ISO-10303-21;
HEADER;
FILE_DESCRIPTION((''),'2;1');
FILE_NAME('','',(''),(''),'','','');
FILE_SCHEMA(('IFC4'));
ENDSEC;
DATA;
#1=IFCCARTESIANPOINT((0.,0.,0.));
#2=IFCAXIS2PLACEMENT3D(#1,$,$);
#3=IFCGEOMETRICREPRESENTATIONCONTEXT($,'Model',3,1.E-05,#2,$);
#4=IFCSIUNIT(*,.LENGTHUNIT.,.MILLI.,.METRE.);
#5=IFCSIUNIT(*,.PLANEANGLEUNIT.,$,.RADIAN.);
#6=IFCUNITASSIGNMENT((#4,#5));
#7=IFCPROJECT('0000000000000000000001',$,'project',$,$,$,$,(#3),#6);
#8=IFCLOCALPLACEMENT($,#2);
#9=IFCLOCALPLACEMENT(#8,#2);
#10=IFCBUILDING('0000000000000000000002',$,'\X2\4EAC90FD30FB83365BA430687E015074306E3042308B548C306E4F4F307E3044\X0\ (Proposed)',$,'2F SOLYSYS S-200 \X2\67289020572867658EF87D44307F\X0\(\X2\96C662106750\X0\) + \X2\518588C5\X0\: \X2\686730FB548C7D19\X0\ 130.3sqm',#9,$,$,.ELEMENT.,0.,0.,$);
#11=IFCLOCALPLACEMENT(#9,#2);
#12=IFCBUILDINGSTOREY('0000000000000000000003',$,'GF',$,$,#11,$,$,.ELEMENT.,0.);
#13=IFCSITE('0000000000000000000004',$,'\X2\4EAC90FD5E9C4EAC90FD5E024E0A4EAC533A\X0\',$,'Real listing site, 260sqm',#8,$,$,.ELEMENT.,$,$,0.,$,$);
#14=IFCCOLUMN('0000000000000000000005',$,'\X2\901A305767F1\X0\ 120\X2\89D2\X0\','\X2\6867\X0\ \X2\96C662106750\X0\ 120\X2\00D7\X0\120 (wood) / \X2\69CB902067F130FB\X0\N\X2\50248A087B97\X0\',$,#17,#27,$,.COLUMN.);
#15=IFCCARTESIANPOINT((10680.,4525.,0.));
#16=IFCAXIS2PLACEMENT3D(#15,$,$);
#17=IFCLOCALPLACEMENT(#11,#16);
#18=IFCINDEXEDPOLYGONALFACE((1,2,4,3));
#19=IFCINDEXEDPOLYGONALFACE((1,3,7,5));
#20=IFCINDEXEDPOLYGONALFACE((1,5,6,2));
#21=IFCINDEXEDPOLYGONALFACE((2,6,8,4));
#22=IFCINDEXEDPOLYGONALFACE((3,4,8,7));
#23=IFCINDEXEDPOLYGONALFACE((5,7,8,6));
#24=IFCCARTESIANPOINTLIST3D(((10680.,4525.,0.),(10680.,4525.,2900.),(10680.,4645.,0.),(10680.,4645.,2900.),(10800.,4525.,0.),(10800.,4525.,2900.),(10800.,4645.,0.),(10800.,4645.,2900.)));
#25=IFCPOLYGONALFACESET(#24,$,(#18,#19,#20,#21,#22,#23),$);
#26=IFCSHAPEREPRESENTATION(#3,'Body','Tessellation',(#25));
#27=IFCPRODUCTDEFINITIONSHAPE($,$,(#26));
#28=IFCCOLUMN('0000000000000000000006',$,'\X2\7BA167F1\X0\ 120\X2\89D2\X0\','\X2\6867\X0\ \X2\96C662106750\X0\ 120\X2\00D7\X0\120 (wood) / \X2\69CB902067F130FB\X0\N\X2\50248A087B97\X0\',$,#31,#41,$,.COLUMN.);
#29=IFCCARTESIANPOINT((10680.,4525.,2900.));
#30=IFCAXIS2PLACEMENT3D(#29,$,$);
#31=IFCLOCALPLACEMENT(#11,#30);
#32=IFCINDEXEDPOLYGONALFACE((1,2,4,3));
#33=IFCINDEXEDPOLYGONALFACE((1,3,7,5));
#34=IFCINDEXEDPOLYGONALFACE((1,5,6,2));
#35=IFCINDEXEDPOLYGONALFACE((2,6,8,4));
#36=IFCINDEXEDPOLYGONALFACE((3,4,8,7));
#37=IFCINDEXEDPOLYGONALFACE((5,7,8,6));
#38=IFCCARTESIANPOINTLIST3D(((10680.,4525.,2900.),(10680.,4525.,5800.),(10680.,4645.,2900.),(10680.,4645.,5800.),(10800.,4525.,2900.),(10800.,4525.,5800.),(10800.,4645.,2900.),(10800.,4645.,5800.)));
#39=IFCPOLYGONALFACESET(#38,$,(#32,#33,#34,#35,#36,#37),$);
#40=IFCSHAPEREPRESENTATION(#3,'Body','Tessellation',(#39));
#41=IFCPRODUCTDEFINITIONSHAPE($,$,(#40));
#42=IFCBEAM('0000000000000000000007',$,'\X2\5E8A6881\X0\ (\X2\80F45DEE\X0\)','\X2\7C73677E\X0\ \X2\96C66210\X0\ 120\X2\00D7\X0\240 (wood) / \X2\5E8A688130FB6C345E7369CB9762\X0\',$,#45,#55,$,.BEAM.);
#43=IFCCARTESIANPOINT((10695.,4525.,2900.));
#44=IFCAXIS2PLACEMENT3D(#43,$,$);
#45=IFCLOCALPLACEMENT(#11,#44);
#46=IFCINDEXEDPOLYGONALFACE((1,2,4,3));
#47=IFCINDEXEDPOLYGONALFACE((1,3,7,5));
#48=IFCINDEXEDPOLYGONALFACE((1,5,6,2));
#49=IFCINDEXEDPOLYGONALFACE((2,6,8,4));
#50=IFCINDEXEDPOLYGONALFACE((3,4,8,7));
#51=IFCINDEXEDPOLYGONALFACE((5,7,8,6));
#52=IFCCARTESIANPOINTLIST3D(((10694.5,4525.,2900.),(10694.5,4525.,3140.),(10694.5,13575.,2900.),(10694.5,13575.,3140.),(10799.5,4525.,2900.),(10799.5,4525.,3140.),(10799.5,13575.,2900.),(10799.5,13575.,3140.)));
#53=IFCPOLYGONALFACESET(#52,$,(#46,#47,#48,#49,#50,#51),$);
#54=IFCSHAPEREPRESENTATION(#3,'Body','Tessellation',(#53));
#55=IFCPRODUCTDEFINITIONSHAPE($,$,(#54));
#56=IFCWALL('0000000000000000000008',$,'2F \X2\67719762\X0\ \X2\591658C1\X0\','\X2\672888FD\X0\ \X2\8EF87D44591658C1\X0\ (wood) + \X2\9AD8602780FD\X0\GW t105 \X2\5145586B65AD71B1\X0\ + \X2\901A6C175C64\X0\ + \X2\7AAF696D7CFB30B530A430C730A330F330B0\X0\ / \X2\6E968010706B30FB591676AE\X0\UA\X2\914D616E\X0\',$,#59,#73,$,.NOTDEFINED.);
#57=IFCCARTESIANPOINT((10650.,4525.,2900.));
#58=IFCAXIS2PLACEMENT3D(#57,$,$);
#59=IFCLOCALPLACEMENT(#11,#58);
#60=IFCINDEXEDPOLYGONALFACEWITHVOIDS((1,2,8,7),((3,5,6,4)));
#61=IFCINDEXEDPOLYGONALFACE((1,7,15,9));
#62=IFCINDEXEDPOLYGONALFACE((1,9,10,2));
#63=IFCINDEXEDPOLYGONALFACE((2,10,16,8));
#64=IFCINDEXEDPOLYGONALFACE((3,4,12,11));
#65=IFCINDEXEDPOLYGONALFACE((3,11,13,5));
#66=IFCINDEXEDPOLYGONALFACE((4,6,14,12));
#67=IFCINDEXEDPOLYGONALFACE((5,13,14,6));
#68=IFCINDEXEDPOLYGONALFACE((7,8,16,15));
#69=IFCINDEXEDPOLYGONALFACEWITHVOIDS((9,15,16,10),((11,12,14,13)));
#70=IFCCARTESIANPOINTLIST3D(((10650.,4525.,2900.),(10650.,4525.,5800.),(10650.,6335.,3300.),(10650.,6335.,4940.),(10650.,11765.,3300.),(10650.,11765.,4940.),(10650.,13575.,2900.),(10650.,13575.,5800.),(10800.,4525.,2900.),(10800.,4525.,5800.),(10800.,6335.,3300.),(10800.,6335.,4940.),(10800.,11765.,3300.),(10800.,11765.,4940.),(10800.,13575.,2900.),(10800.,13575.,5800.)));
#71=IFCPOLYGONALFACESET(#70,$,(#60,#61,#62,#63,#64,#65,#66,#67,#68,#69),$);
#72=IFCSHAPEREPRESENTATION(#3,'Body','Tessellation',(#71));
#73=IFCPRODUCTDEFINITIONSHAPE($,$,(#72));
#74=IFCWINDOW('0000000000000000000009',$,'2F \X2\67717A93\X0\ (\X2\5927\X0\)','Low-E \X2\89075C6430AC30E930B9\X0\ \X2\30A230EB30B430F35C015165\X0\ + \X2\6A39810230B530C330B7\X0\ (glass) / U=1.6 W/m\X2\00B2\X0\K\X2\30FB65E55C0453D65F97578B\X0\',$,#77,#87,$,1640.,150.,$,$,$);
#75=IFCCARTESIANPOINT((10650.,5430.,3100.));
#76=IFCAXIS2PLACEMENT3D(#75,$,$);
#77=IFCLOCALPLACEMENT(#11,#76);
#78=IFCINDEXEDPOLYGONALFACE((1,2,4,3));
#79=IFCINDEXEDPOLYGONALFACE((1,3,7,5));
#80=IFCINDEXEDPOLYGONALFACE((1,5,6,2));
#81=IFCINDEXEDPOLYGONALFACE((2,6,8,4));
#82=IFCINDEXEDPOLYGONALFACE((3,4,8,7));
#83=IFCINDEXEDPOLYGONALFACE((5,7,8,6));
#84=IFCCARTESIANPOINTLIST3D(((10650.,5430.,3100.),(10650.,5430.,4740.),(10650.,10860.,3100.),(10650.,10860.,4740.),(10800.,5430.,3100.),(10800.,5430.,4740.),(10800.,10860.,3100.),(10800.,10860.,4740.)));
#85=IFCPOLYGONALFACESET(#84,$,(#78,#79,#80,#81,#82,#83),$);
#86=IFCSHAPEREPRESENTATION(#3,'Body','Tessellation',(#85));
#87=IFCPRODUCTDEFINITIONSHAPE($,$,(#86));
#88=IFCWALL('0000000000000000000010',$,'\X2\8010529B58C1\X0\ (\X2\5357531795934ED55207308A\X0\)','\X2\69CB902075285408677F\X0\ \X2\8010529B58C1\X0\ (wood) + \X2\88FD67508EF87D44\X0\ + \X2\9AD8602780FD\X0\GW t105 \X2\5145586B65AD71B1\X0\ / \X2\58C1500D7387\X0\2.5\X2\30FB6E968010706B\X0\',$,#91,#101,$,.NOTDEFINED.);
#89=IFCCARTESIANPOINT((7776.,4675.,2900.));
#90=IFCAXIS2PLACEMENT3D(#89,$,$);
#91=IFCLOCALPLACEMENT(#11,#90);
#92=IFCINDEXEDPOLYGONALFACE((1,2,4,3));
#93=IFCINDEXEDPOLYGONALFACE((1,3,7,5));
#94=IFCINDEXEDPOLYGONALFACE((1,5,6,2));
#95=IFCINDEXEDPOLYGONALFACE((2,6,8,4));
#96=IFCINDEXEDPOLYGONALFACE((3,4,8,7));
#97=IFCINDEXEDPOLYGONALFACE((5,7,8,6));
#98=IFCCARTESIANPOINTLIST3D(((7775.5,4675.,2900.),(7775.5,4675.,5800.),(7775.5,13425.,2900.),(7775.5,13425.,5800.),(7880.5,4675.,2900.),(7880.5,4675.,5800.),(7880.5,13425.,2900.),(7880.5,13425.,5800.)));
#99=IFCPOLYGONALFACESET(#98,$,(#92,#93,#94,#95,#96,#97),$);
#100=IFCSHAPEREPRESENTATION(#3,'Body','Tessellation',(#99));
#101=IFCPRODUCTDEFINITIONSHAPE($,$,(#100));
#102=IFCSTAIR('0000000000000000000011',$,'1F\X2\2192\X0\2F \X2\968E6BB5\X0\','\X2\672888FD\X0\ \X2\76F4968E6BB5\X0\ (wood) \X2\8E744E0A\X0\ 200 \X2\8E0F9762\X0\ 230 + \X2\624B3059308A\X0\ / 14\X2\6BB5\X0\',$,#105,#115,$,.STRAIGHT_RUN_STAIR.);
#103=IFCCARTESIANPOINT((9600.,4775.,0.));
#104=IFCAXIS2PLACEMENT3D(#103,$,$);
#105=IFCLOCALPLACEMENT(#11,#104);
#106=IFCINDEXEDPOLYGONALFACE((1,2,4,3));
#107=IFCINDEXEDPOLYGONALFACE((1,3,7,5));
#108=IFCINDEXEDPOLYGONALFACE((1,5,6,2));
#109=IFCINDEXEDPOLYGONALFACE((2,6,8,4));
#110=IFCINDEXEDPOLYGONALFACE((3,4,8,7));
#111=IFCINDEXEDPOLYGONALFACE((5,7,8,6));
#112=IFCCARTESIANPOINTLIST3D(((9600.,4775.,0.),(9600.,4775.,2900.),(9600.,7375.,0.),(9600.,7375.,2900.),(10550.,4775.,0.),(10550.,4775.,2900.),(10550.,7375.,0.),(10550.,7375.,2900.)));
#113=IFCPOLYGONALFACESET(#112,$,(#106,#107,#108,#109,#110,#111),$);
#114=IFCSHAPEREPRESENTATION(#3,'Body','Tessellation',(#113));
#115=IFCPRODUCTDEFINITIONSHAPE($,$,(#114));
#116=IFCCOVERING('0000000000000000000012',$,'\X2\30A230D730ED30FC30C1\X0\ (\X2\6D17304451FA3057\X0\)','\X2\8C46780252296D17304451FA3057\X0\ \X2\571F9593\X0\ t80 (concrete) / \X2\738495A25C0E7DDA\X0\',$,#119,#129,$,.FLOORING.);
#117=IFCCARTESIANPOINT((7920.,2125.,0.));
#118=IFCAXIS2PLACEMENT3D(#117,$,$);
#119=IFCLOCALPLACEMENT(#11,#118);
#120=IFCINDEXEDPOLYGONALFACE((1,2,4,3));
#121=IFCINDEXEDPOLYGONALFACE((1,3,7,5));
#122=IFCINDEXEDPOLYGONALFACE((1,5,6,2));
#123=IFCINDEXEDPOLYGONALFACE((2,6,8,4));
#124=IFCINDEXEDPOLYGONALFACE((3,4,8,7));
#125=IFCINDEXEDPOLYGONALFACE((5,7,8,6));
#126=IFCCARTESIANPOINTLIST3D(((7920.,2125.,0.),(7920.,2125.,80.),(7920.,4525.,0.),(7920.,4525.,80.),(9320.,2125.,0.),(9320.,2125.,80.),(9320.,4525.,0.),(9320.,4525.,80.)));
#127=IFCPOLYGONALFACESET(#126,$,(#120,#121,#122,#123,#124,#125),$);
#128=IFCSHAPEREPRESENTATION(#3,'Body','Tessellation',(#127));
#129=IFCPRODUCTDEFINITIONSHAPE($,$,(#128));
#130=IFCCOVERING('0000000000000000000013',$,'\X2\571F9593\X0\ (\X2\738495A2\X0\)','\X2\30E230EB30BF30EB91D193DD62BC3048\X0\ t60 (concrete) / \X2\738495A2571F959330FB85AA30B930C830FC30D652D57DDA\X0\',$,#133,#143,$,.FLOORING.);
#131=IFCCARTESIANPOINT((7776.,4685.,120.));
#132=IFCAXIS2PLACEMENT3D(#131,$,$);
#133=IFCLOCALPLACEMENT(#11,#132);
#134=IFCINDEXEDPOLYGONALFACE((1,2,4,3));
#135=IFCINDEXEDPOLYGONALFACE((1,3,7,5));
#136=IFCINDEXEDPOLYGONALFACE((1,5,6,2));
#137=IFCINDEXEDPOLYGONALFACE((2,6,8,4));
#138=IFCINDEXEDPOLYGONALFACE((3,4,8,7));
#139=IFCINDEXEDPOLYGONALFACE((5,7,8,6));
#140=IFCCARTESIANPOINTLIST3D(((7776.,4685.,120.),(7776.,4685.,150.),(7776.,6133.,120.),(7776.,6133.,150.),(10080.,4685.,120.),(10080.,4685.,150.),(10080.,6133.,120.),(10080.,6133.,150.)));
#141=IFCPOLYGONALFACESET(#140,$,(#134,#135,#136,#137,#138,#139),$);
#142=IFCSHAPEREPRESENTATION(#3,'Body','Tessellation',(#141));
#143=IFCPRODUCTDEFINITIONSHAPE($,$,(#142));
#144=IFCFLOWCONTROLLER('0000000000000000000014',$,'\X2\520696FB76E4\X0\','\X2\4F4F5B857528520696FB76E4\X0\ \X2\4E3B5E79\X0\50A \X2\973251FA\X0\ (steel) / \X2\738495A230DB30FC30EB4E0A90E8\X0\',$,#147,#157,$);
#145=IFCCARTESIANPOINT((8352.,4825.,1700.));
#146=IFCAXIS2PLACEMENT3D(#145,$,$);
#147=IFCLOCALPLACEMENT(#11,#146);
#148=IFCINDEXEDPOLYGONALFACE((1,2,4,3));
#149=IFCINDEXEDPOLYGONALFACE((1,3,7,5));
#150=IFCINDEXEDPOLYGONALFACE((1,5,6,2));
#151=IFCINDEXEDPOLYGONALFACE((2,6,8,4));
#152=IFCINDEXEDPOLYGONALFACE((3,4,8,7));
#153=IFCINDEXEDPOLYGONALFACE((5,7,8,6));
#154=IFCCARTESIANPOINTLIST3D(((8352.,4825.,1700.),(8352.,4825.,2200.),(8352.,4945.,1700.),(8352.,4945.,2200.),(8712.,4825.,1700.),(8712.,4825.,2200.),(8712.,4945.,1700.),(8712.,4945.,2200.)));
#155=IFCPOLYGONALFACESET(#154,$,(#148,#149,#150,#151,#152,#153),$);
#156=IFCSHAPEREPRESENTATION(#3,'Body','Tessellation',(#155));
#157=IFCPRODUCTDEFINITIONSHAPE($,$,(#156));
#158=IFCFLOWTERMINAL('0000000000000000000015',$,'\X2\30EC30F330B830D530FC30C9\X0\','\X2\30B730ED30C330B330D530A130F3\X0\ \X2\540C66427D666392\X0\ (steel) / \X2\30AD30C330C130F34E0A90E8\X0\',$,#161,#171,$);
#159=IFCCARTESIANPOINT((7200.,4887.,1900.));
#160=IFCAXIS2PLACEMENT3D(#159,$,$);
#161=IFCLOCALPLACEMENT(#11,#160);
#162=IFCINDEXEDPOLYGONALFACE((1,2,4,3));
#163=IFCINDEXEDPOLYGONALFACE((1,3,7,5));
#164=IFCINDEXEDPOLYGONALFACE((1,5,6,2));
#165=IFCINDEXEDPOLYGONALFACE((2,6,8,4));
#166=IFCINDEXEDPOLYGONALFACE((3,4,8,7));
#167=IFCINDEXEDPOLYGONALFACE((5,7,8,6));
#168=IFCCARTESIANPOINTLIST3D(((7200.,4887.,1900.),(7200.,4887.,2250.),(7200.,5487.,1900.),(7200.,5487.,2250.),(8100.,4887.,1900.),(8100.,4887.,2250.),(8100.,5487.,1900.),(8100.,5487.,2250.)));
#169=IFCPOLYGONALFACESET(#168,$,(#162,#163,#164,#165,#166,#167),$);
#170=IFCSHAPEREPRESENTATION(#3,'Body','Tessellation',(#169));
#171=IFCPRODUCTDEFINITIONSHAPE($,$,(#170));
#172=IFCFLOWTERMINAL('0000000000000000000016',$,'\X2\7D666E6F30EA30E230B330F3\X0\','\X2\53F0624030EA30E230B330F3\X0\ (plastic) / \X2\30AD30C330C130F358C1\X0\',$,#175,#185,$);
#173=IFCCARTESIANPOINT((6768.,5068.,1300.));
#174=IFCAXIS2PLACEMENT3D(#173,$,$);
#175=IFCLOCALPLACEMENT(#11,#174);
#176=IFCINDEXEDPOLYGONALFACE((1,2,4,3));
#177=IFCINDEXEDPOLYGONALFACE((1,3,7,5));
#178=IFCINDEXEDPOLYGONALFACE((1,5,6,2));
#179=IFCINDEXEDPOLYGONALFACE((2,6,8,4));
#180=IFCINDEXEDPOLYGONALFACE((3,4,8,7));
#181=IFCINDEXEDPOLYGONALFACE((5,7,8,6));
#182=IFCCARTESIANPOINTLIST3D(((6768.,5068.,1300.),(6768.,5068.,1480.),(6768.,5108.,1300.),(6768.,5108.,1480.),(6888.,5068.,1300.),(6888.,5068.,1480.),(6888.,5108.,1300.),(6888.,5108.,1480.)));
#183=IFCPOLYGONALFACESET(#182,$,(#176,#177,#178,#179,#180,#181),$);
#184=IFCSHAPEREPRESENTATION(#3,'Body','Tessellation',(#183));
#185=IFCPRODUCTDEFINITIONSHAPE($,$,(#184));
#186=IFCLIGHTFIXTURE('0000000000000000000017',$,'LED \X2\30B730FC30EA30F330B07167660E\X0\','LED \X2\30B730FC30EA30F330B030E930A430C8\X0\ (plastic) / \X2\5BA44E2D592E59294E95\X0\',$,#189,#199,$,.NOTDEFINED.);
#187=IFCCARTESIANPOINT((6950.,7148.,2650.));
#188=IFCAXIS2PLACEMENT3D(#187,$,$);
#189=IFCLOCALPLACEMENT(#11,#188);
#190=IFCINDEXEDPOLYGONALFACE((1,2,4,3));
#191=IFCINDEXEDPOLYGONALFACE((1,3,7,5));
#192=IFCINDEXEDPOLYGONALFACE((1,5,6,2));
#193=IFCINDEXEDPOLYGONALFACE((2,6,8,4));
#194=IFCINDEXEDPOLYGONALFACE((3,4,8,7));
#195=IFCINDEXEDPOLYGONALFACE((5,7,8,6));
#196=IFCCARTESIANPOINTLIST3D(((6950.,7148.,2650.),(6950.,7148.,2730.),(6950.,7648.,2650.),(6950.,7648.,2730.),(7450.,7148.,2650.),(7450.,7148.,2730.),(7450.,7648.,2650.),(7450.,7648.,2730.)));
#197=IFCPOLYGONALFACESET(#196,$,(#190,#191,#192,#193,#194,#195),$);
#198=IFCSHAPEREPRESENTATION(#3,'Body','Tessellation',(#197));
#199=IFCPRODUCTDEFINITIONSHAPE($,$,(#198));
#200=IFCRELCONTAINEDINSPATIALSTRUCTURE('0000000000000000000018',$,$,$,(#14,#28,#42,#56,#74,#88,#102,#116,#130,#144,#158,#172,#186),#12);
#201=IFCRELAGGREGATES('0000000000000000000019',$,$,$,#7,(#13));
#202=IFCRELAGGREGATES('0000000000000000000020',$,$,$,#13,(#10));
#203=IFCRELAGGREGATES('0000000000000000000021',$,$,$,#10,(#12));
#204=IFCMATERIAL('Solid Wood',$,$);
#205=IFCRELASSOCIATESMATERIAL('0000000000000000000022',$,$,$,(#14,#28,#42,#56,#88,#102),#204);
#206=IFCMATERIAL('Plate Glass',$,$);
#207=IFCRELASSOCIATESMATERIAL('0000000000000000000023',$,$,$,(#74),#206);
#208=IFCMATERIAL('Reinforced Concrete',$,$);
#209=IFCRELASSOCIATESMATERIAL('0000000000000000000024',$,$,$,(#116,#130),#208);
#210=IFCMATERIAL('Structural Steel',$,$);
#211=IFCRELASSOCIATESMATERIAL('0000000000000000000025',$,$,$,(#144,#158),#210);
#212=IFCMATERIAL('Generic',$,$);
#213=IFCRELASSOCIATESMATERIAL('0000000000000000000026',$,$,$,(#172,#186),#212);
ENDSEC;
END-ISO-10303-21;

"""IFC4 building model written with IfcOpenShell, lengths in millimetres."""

from ifc_helpers import new_model, si_unit, frame, frame_2d, origin, place, context, project, spatial, rectangle, extrude, material, element, fill, save


model = new_model("IFC4")

# Units and contexts
model_context = context("Model", 3, precision=1e-05, world=origin())
ifc_project = project(units=[si_unit("LENGTHUNIT", "METRE", prefix="MILLI"), si_unit("PLANEANGLEUNIT", "RADIAN")], contexts=[model_context])

# Site, building, storey
site_placement = place(None, origin())
site = spatial("IfcSite", under=ifc_project, at=site_placement, Name="京都府京都市上京区", ObjectType="Real listing site, 260sqm", CompositionType="ELEMENT", RefElevation=0.0)
building_placement = place(site_placement, origin())
building = spatial("IfcBuilding", under=site, at=building_placement, Name="京都・茶室と縁側のある和の住まい (Proposed)", ObjectType="2F SOLYSYS S-200 木造在来軸組み(集成材) + 内装: 桧・和紙 130.3sqm", CompositionType="ELEMENT", ElevationOfRefHeight=0.0, ElevationOfTerrain=0.0)
storey_placement = place(building_placement, origin())
storey = spatial("IfcBuildingStorey", under=building, at=storey_placement, Name="GF", CompositionType="ELEMENT", Elevation=0.0)

# Columns
ifc_material_1 = material(Name="Solid Wood")
column_1_placement = place(storey_placement, frame((10680.0, 4525.0, 0.0)))
element("IfcColumn", 1, at=column_1_placement, inside=storey, material=ifc_material_1, Name="通し柱 120角", Description="桧 集成材 120×120 (wood) / 構造柱・N値計算", PredefinedType="COLUMN", context=model_context, shape_type="SweptSolid", body=[
    extrude(rectangle(XDim=120.0, YDim=120.0, at=frame_2d((60.0, 60.0))), frame((10680.0, 4525.0, 0.0)), (0.0, 0.0, 1.0), 2900.0),
])
column_2_placement = place(storey_placement, frame((10680.0, 4525.0, 2900.0)))
element("IfcColumn", 2, at=column_2_placement, inside=storey, material=ifc_material_1, Name="管柱 120角", Description="桧 集成材 120×120 (wood) / 構造柱・N値計算", PredefinedType="COLUMN", context=model_context, shape_type="SweptSolid", body=[
    extrude(rectangle(XDim=120.0, YDim=120.0, at=frame_2d((60.0, 60.0))), frame((10680.0, 4525.0, 2900.0)), (0.0, 0.0, 1.0), 2900.0),
])

# Beam
beam_1_placement = place(storey_placement, frame((10695.0, 4525.0, 2900.0)))
element("IfcBeam", 3, at=beam_1_placement, inside=storey, material=ifc_material_1, Name="床梁 (胴差)", Description="米松 集成 120×240 (wood) / 床梁・水平構面", PredefinedType="BEAM", context=model_context, shape_type="SweptSolid", body=[
    extrude(rectangle(XDim=105.0, YDim=9050.0, at=frame_2d((52.0, 4525.0))), frame((10695.0, 4525.0, 2900.0)), (0.0, 0.0, 1.0), 240.0),
])

# Shared definitions
ifc_material_2 = material(Name="Plate Glass")

# Wall, opening, window
wall_1_placement = place(storey_placement, frame((10650.0, 4525.0, 2900.0)))
wall_1 = element("IfcWall", 4, at=wall_1_placement, inside=storey, material=ifc_material_1, Name="2F 東面 外壁", Description="木製 軸組外壁 (wood) + 高性能GW t105 充填断熱 + 通気層 + 窯業系サイディング / 準耐火・外皮UA配慮", PredefinedType="NOTDEFINED", context=model_context, shape_type="SweptSolid", body=[
    extrude(rectangle(XDim=150.0, YDim=9050.0, at=frame_2d((75.0, 4525.0))), frame((10650.0, 4525.0, 2900.0)), (0.0, 0.0, 1.0), 2900.0),
])
opening_1_placement = place(storey_placement, frame((10650.0, 5430.0, 3100.0)))
opening_1 = element("IfcOpeningElement", 5, at=opening_1_placement, cuts=wall_1, PredefinedType="NOTDEFINED", context=model_context, shape_type="SweptSolid", body=[
    extrude(rectangle(XDim=150.0, YDim=5430.0, at=frame_2d((75.0, 2715.0))), frame((10650.0, 5430.0, 3100.0)), (0.0, 0.0, 1.0), 1640.0),
])
window_1_placement = place(storey_placement, frame((10650.0, 5430.0, 3100.0)))
window_1 = element("IfcWindow", 6, at=window_1_placement, inside=storey, material=ifc_material_2, Name="2F 東窓 (大)", Description="Low-E 複層ガラス アルゴン封入 + 樹脂サッシ (glass) / U=1.6 W/m²K・日射取得型", OverallHeight=1640.0, OverallWidth=150.0, context=model_context, shape_type="SweptSolid", body=[
    extrude(rectangle(XDim=150.0, YDim=5430.0, at=frame_2d((75.0, 2715.0))), frame((10650.0, 5430.0, 3100.0)), (0.0, 0.0, 1.0), 1640.0),
])
fill(opening_1, window_1)

# Wall
wall_2_placement = place(storey_placement, frame((7776.0, 4675.0, 2900.0)))
element("IfcWall", 7, at=wall_2_placement, inside=storey, material=ifc_material_1, Name="耐力壁 (南北間仕切り)", Description="構造用合板 耐力壁 (wood) + 製材軸組 + 高性能GW t105 充填断熱 / 壁倍率2.5・準耐火", PredefinedType="NOTDEFINED", context=model_context, shape_type="SweptSolid", body=[
    extrude(rectangle(XDim=105.0, YDim=8750.0, at=frame_2d((52.0, 4375.0))), frame((7776.0, 4675.0, 2900.0)), (0.0, 0.0, 1.0), 2900.0),
])

# Stair
stair_placement = place(storey_placement, frame((9600.0, 4775.0, 0.0)))
element("IfcStair", 8, at=stair_placement, inside=storey, material=ifc_material_1, Name="1F→2F 階段", Description="木製 直階段 (wood) 蹴上 200 踏面 230 + 手すり / 14段", PredefinedType="STRAIGHT_RUN_STAIR", context=model_context, shape_type="SweptSolid", body=[
    extrude(rectangle(XDim=950.0, YDim=2600.0, at=frame_2d((475.0, 1300.0))), frame((9600.0, 4775.0, 0.0)), (0.0, 0.0, 1.0), 2900.0),
])

# Coverings
ifc_material_3 = material(Name="Reinforced Concrete")
covering_1_placement = place(storey_placement, frame((7920.0, 2125.0, 0.0)))
element("IfcCovering", 9, at=covering_1_placement, inside=storey, material=ifc_material_3, Name="アプローチ (洗い出し)", Description="豆砂利洗い出し 土間 t80 (concrete) / 玄関導線", PredefinedType="FLOORING", context=model_context, shape_type="SweptSolid", body=[
    extrude(rectangle(XDim=1400.0, YDim=2400.0, at=frame_2d((700.0, 1200.0))), frame((7920.0, 2125.0, 0.0)), (0.0, 0.0, 1.0), 80.0),
])
covering_2_placement = place(storey_placement, frame((7776.0, 4685.0, 120.0)))
element("IfcCovering", 10, at=covering_2_placement, inside=storey, material=ifc_material_3, Name="土間 (玄関)", Description="モルタル金鏝押え t60 (concrete) / 玄関土間・薪ストーブ動線", PredefinedType="FLOORING", context=model_context, shape_type="SweptSolid", body=[
    extrude(rectangle(XDim=2304.0, YDim=1448.0, at=frame_2d((1152.0, 724.0))), frame((7776.0, 4685.0, 120.0)), (0.0, 0.0, 1.0), 30.0),
])

# Flow controller
ifc_material_4 = material(Name="Structural Steel")
flow_controller_placement = place(storey_placement, frame((8352.0, 4825.0, 1700.0)))
element("IfcFlowController", 11, at=flow_controller_placement, inside=storey, material=ifc_material_4, Name="分電盤", Description="住宅用分電盤 主幹50A 露出 (steel) / 玄関ホール上部", context=model_context, shape_type="SweptSolid", body=[
    extrude(rectangle(XDim=360.0, YDim=120.0, at=frame_2d((180.0, 60.0))), frame((8352.0, 4825.0, 1700.0)), (0.0, 0.0, 1.0), 500.0),
])

# Flow terminals
flow_terminal_1_placement = place(storey_placement, frame((7200.0, 4887.0, 1900.0)))
element("IfcFlowTerminal", 12, at=flow_terminal_1_placement, inside=storey, material=ifc_material_4, Name="レンジフード", Description="シロッコファン 同時給排 (steel) / キッチン上部", context=model_context, shape_type="SweptSolid", body=[
    extrude(rectangle(XDim=900.0, YDim=600.0, at=frame_2d((450.0, 300.0))), frame((7200.0, 4887.0, 1900.0)), (0.0, 0.0, 1.0), 350.0),
])
ifc_material_5 = material(Name="Generic")
flow_terminal_2_placement = place(storey_placement, frame((6768.0, 5068.0, 1300.0)))
element("IfcFlowTerminal", 13, at=flow_terminal_2_placement, inside=storey, material=ifc_material_5, Name="給湯リモコン", Description="台所リモコン (plastic) / キッチン壁", context=model_context, shape_type="SweptSolid", body=[
    extrude(rectangle(XDim=120.0, YDim=40.0, at=frame_2d((60.0, 20.0))), frame((6768.0, 5068.0, 1300.0)), (0.0, 0.0, 1.0), 180.0),
])

# Light fixture
light_fixture_1_placement = place(storey_placement, frame((6950.0, 7148.0, 2650.0)))
element("IfcLightFixture", 14, at=light_fixture_1_placement, inside=storey, material=ifc_material_5, Name="LED シーリング照明", Description="LED シーリングライト (plastic) / 室中央天井", PredefinedType="NOTDEFINED", context=model_context, shape_type="SweptSolid", body=[
    extrude(rectangle(XDim=500.0, YDim=500.0, at=frame_2d((250.0, 250.0))), frame((6950.0, 7148.0, 2650.0)), (0.0, 0.0, 1.0), 80.0),
])

save(model, "model.ifc")
